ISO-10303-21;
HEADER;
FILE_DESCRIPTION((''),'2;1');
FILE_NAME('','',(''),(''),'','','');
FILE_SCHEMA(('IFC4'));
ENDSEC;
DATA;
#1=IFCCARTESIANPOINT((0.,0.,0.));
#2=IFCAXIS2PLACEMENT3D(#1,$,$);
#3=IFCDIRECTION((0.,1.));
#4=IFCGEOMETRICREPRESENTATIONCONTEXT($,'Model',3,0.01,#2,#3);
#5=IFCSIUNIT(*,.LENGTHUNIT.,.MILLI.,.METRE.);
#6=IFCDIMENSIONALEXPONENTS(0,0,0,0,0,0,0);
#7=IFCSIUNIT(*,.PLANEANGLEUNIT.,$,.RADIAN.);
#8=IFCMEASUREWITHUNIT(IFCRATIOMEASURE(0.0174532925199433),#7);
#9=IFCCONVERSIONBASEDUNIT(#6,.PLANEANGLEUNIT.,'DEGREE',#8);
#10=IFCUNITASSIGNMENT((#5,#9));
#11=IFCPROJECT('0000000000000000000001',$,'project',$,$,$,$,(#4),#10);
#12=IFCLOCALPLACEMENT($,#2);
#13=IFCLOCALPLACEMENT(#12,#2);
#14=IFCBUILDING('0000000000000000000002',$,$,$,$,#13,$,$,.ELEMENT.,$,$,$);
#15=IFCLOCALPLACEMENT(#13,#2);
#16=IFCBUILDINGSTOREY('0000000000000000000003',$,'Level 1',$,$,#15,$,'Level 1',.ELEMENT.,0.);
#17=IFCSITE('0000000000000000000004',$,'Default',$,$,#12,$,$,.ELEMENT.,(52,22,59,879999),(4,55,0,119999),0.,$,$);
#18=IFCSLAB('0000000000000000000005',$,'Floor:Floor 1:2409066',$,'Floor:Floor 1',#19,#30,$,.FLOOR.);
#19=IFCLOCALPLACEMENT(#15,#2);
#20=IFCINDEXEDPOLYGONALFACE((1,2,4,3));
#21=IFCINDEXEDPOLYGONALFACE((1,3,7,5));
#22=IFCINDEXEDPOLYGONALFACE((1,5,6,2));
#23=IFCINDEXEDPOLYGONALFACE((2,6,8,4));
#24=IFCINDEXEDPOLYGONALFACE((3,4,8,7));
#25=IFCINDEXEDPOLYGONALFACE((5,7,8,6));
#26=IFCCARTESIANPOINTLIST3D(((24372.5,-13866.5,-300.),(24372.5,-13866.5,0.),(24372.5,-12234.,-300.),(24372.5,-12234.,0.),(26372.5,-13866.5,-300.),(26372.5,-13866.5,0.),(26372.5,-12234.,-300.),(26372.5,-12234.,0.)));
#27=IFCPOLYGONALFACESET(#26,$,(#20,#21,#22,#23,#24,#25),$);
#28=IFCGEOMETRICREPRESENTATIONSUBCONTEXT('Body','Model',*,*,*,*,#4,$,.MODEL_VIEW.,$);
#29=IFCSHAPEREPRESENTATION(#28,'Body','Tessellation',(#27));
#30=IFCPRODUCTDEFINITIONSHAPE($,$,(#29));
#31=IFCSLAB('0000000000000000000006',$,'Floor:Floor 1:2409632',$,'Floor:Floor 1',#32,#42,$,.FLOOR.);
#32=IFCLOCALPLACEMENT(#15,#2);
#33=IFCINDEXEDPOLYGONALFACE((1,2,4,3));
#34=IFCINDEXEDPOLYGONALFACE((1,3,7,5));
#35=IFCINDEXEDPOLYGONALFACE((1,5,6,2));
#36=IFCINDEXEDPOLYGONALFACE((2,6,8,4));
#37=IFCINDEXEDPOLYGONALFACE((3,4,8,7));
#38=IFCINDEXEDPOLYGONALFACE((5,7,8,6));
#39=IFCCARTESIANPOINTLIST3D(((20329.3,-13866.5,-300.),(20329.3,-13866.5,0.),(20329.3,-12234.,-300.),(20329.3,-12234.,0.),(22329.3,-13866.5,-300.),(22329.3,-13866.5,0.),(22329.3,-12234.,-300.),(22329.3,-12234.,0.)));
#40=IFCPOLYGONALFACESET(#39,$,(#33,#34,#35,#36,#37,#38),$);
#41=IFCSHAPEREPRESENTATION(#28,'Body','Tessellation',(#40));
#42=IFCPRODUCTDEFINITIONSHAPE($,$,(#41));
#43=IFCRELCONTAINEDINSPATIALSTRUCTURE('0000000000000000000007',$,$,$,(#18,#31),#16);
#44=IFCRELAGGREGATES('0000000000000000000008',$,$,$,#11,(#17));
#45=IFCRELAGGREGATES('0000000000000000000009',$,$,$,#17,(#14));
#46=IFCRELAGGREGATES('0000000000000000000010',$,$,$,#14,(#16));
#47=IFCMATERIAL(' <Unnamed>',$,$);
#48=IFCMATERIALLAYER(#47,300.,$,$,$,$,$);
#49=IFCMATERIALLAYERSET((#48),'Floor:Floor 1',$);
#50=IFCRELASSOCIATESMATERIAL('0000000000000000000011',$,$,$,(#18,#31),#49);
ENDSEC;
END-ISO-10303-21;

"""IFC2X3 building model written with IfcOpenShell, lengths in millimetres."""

from ifc_helpers import new_model, entity, si_unit, converted_unit, direction, frame, frame_2d, origin, place, context, subcontext, project, spatial, rectangle, extrude, material, layer, layer_set, layer_usage, element, save


model = new_model("IFC2X3")

# Units and contexts
model_context = context("Model", 3, precision=0.01, world=origin(), true_north=direction((0.0, 1.0)))
body_context = subcontext(model_context, "Body", "Model", "MODEL_VIEW")
ifc_project = project(units=[si_unit("LENGTHUNIT", "METRE", prefix="MILLI"), converted_unit("PLANEANGLEUNIT", "DEGREE", entity("IfcRatioMeasure", 0.0174532925199433), si_unit("PLANEANGLEUNIT", "RADIAN"), dimensions=[0, 0, 0, 0, 0, 0, 0])], contexts=[model_context])

# Site, building, storey
site_placement = place(None, origin())
site = spatial("IfcSite", under=ifc_project, at=site_placement, Name="Default", CompositionType="ELEMENT", RefLatitude=(52, 22, 59, 879999), RefLongitude=(4, 55, 0, 119999), RefElevation=0.0)
building_placement = place(site_placement, origin())
building = spatial("IfcBuilding", under=site, at=building_placement, CompositionType="ELEMENT")
storey_placement = place(building_placement, origin())
storey = spatial("IfcBuildingStorey", under=building, at=storey_placement, Name="Level 1", LongName="Level 1", CompositionType="ELEMENT", Elevation=0.0)

# Slabs
ifc_material = material(Name=" <Unnamed>")
ifc_layer = layer(ifc_material, 300.0)
ifc_layer_set = layer_set([ifc_layer], Name="Floor:Floor 1")
ifc_layer_usage_1 = layer_usage(ifc_layer_set, "AXIS3", "POSITIVE", 0.0)
slab_1_placement = place(storey_placement, origin())
element("IfcSlab", 1, at=slab_1_placement, inside=storey, material=ifc_layer_usage_1, Name="Floor:Floor 1:2409066", ObjectType="Floor:Floor 1", PredefinedType="FLOOR", context=body_context, shape_type="SweptSolid", body=[
    extrude(rectangle(XDim=1632.5, YDim=2000.0, at=frame_2d((0.0, 0.0), x_axis=(1.0, 0.0))), frame((25372.5, -13050.3, 0.0), z_axis=(0.0, 0.0, -1.0), x_axis=(0.0, 1.0, 0.0)), (0.0, 0.0, 1.0), 300.0),
])
ifc_layer_usage_2 = layer_usage(ifc_layer_set, "AXIS3", "POSITIVE", 0.0)
slab_2_placement = place(storey_placement, origin())
element("IfcSlab", 2, at=slab_2_placement, inside=storey, material=ifc_layer_usage_2, Name="Floor:Floor 1:2409632", ObjectType="Floor:Floor 1", PredefinedType="FLOOR", context=body_context, shape_type="SweptSolid", body=[
    extrude(rectangle(XDim=1632.5, YDim=2000.0, at=frame_2d((0.0, 0.0), x_axis=(1.0, 0.0))), frame((21329.3, -13050.3, 0.0), z_axis=(0.0, 0.0, -1.0), x_axis=(0.0, 1.0, 0.0)), (0.0, 0.0, 1.0), 300.0),
])

save(model, "model.ifc")
